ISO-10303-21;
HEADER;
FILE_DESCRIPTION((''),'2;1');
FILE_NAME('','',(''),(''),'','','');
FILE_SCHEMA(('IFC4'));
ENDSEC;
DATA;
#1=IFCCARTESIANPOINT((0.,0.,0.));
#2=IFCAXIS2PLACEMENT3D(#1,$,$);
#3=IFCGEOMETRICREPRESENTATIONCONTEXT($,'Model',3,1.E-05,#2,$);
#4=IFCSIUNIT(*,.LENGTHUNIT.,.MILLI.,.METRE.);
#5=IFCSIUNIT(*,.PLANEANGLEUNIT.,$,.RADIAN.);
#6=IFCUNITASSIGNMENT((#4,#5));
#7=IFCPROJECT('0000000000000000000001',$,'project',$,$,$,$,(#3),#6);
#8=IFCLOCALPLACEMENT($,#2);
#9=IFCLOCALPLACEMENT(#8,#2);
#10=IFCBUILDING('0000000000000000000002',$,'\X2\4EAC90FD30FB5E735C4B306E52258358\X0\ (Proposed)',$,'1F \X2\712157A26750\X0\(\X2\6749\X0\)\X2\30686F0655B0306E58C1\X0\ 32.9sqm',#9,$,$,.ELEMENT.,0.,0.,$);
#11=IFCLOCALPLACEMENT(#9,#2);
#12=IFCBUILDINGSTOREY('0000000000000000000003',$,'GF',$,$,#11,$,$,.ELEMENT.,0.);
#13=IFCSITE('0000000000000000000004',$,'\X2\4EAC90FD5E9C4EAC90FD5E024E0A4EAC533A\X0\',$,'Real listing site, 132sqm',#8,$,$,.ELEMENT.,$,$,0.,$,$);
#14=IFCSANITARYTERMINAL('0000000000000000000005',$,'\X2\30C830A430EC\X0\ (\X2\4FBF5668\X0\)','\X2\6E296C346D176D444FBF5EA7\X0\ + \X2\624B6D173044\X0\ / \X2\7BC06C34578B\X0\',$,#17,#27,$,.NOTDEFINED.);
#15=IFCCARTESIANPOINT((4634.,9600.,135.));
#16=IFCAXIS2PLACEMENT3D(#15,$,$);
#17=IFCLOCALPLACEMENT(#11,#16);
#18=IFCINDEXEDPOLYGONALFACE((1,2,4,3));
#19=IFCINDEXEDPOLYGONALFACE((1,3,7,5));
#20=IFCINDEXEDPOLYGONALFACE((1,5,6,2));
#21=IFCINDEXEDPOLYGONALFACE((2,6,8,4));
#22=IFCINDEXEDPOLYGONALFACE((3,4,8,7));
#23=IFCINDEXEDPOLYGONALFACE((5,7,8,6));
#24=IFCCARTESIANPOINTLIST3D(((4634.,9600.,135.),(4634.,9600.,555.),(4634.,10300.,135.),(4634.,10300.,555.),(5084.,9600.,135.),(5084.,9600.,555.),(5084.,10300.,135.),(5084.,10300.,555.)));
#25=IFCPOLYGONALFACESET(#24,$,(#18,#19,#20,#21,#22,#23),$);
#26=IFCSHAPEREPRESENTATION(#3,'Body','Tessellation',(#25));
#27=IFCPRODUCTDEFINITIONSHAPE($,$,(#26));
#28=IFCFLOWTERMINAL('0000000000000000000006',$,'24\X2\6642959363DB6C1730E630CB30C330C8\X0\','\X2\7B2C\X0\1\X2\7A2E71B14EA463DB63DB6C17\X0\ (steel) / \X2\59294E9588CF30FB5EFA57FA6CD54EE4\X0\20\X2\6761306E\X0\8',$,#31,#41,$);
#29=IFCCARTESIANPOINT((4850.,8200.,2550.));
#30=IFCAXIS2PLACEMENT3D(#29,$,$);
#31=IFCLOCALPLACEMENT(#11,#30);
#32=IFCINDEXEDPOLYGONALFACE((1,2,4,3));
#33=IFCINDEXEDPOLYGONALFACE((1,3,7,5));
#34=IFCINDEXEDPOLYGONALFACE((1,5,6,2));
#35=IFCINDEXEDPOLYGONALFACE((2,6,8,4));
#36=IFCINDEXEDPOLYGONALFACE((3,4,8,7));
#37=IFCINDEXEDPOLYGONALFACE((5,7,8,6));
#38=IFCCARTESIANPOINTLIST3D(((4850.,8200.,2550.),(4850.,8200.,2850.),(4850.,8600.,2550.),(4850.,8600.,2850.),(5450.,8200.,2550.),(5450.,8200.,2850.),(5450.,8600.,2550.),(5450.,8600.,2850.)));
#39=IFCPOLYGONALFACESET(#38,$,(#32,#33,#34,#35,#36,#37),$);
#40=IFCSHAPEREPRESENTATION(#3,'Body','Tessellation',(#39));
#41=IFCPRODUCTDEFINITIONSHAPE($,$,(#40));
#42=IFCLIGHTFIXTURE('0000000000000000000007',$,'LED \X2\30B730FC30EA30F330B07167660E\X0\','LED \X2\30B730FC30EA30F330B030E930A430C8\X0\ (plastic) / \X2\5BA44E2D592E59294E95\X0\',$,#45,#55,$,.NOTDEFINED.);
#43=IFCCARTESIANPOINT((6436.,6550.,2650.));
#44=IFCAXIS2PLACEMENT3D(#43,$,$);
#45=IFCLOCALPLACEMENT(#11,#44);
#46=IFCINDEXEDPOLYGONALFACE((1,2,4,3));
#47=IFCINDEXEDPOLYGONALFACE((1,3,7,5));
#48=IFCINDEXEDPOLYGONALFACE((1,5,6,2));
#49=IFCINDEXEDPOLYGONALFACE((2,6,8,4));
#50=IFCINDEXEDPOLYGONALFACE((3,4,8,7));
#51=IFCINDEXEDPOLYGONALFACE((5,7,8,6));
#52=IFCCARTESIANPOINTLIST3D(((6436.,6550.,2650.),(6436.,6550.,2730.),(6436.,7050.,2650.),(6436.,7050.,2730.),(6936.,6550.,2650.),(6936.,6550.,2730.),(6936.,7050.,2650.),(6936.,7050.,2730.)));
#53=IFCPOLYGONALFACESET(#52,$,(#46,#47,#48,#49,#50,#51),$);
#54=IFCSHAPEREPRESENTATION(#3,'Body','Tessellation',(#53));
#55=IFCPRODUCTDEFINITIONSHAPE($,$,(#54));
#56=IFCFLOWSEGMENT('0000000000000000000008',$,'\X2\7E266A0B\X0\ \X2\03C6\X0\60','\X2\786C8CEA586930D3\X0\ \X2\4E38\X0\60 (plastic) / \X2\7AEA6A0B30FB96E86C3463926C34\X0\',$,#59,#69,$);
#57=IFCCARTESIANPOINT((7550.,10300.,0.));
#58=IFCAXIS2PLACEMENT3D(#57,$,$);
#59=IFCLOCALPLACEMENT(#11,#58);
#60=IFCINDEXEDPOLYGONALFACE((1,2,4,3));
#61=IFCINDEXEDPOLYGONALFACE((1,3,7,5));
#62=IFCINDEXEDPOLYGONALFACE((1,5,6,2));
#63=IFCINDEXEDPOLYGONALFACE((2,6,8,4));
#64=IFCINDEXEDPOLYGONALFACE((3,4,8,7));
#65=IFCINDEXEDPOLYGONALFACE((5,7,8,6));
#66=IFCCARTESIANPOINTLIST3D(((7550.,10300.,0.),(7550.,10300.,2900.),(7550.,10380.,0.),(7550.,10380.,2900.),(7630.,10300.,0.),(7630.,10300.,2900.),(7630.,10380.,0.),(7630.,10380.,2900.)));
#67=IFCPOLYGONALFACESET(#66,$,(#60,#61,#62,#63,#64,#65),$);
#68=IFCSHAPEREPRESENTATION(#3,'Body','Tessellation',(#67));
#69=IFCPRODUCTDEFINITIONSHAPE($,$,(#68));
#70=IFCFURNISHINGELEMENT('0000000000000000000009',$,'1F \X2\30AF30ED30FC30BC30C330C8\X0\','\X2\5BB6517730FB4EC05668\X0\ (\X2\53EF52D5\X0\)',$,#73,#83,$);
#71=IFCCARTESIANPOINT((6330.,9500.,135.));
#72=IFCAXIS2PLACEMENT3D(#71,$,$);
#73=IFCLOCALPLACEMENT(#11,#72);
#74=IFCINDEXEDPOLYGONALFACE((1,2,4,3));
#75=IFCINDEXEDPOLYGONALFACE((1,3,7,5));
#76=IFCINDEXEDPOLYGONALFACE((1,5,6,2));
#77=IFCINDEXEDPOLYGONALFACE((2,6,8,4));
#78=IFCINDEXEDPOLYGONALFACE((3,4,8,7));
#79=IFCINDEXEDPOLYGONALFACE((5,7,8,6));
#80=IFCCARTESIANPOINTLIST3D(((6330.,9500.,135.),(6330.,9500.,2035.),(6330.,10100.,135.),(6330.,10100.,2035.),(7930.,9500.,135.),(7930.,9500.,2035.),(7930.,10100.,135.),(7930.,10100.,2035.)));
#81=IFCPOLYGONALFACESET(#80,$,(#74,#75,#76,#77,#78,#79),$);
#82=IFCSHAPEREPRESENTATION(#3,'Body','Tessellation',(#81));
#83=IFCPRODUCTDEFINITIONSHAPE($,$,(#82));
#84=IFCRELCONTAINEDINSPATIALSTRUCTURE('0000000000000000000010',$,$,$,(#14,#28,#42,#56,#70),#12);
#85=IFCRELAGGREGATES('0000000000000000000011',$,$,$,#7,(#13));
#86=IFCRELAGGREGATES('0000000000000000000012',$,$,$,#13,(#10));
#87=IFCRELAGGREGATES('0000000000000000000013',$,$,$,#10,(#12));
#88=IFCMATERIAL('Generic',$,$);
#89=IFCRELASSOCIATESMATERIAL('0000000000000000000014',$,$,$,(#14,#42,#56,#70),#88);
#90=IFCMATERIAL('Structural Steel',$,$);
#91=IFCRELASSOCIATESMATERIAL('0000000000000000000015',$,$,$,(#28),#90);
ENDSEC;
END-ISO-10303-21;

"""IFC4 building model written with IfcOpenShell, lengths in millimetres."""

from ifc_helpers import new_model, si_unit, frame, frame_2d, origin, place, context, project, spatial, rectangle, extrude, material, element, save


model = new_model("IFC4")

# Units and contexts
model_context = context("Model", 3, precision=1e-05, world=origin())
ifc_project = project(units=[si_unit("LENGTHUNIT", "METRE", prefix="MILLI"), si_unit("PLANEANGLEUNIT", "RADIAN")], contexts=[model_context])

# Site, building, storey
site_placement = place(None, origin())
site = spatial("IfcSite", under=ifc_project, at=site_placement, Name="京都府京都市上京区", ObjectType="Real listing site, 132sqm", CompositionType="ELEMENT", RefElevation=0.0)
building_placement = place(site_placement, origin())
building = spatial("IfcBuilding", under=site, at=building_placement, Name="京都・平屋の別荘 (Proposed)", ObjectType="1F 無垢材(杉)と漆喰の壁 32.9sqm", CompositionType="ELEMENT", ElevationOfRefHeight=0.0, ElevationOfTerrain=0.0)
storey_placement = place(building_placement, origin())
storey = spatial("IfcBuildingStorey", under=building, at=storey_placement, Name="GF", CompositionType="ELEMENT", Elevation=0.0)

# Shared definitions
ifc_material_1 = material(Name="Generic")

# Sanitary terminal
sanitary_terminal_1_placement = place(storey_placement, frame((4634.0, 9600.0, 135.0)))
element("IfcSanitaryTerminal", 1, at=sanitary_terminal_1_placement, inside=storey, material=ifc_material_1, Name="トイレ (便器)", Description="温水洗浄便座 + 手洗い / 節水型", PredefinedType="NOTDEFINED", context=model_context, shape_type="SweptSolid", body=[
    extrude(rectangle(XDim=450.0, YDim=700.0, at=frame_2d((225.0, 350.0))), frame((4634.0, 9600.0, 135.0)), (0.0, 0.0, 1.0), 420.0),
])

# Flow terminal
ifc_material_2 = material(Name="Structural Steel")
flow_terminal_placement = place(storey_placement, frame((4850.0, 8200.0, 2550.0)))
element("IfcFlowTerminal", 2, at=flow_terminal_placement, inside=storey, material=ifc_material_2, Name="24時間換気ユニット", Description="第1種熱交換換気 (steel) / 天井裏・建基法令20条の8", context=model_context, shape_type="SweptSolid", body=[
    extrude(rectangle(XDim=600.0, YDim=400.0, at=frame_2d((300.0, 200.0))), frame((4850.0, 8200.0, 2550.0)), (0.0, 0.0, 1.0), 300.0),
])

# Light fixture
light_fixture_placement = place(storey_placement, frame((6436.0, 6550.0, 2650.0)))
element("IfcLightFixture", 3, at=light_fixture_placement, inside=storey, material=ifc_material_1, Name="LED シーリング照明", Description="LED シーリングライト (plastic) / 室中央天井", PredefinedType="NOTDEFINED", context=model_context, shape_type="SweptSolid", body=[
    extrude(rectangle(XDim=500.0, YDim=500.0, at=frame_2d((250.0, 250.0))), frame((6436.0, 6550.0, 2650.0)), (0.0, 0.0, 1.0), 80.0),
])

# Flow segment
flow_segment_placement = place(storey_placement, frame((7550.0, 10300.0, 0.0)))
element("IfcFlowSegment", 4, at=flow_segment_placement, inside=storey, material=ifc_material_1, Name="縦樋 φ60", Description="硬質塩ビ 丸60 (plastic) / 竪樋・雨水排水", context=model_context, shape_type="SweptSolid", body=[
    extrude(rectangle(XDim=80.0, YDim=80.0, at=frame_2d((40.0, 40.0))), frame((7550.0, 10300.0, 0.0)), (0.0, 0.0, 1.0), 2900.0),
])

# Furnishing element
furnishing_placement = place(storey_placement, frame((6330.0, 9500.0, 135.0)))
element("IfcFurnishingElement", 5, at=furnishing_placement, inside=storey, material=ifc_material_1, Name="1F クローゼット", Description="家具・什器 (可動)", context=model_context, shape_type="SweptSolid", body=[
    extrude(rectangle(XDim=1600.0, YDim=600.0, at=frame_2d((800.0, 300.0))), frame((6330.0, 9500.0, 135.0)), (0.0, 0.0, 1.0), 1900.0),
])

save(model, "model.ifc")
